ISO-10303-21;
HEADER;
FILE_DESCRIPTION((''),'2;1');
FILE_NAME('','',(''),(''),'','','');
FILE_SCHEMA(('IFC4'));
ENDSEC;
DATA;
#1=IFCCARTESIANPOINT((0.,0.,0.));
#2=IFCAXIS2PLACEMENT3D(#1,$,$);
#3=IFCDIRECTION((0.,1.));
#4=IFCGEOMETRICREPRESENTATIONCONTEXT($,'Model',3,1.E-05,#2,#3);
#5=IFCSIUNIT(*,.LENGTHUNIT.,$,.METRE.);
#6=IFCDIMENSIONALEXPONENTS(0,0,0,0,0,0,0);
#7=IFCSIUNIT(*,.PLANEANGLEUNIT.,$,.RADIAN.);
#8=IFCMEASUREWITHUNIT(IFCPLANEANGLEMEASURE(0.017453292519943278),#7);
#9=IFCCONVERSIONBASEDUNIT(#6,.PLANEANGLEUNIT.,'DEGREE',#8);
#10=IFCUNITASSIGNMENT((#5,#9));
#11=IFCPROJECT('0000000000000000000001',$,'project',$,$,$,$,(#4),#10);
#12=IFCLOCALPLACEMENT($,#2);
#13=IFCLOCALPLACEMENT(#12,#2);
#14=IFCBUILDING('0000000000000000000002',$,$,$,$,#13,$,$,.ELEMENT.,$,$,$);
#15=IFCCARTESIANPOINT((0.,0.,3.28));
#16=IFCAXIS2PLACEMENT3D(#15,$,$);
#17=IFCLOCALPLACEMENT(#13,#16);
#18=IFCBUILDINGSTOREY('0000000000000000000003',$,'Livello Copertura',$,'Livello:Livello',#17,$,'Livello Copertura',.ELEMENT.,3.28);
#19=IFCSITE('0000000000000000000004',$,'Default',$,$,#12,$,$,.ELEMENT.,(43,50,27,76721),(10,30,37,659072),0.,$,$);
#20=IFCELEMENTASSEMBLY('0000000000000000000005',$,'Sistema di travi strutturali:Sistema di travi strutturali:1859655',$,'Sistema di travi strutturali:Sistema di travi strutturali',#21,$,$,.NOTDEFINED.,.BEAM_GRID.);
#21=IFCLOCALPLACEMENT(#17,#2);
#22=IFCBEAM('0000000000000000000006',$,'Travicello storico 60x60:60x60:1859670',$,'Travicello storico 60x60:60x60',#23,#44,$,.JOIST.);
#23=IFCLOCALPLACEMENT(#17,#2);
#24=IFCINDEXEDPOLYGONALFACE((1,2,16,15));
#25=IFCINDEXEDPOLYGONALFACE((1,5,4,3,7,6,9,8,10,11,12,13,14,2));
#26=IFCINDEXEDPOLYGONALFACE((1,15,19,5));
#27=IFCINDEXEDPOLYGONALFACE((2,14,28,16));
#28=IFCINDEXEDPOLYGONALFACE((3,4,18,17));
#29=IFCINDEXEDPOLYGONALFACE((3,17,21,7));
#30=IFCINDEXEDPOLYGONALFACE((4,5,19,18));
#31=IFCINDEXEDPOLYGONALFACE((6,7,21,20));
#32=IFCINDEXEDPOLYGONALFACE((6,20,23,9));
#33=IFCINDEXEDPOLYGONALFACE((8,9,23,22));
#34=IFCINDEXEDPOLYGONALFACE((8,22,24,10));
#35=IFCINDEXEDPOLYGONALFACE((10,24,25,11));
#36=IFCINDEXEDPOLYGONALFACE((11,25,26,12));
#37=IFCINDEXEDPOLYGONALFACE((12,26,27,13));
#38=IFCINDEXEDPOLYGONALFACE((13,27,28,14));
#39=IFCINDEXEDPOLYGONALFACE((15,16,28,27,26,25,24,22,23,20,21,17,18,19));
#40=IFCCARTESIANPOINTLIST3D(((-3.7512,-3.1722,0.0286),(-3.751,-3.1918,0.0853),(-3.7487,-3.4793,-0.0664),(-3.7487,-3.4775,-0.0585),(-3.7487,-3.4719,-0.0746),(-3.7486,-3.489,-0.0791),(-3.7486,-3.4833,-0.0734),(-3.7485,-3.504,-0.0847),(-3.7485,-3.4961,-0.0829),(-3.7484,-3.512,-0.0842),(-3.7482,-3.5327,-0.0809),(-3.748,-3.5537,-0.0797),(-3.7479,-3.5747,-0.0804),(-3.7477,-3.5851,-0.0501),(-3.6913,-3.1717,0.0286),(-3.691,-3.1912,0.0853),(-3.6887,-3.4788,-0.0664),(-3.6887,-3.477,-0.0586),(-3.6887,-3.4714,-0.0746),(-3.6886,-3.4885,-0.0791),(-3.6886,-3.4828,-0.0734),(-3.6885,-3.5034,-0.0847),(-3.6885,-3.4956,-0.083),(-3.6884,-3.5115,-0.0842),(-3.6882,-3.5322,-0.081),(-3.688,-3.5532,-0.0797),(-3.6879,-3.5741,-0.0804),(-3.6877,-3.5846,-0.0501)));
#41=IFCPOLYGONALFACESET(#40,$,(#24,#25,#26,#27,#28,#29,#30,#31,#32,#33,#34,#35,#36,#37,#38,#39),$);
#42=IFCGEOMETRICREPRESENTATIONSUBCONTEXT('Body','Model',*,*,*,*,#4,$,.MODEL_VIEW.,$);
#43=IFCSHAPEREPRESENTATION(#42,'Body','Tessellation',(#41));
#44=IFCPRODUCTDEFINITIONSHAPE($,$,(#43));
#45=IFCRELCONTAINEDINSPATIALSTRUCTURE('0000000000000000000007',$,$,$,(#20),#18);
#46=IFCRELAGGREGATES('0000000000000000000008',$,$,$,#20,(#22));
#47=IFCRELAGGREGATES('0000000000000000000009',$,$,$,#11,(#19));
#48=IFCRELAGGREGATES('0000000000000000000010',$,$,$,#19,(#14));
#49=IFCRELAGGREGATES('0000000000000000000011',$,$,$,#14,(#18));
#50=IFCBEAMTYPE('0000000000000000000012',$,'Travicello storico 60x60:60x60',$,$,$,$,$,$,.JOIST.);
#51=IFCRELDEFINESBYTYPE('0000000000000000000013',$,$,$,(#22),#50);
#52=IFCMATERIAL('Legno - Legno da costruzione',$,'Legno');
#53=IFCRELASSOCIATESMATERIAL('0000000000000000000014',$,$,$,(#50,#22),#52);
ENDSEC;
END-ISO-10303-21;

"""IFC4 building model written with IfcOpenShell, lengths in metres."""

from ifc_helpers import new_model, entity, si_unit, converted_unit, direction, frame, origin, place, context, subcontext, project, spatial, line, arc, indexed_curve, outline, extrude, source, transform, mapped, material, type_object, type_shapes, element, aggregate, save


model = new_model("IFC4")

# Units and contexts
model_context = context("Model", 3, precision=1e-05, world=origin(), true_north=direction((0.0, 1.0)))
body_context = subcontext(model_context, "Body", "Model", "MODEL_VIEW")
ifc_project = project(units=[si_unit("LENGTHUNIT", "METRE"), converted_unit("PLANEANGLEUNIT", "DEGREE", entity("IfcPlaneAngleMeasure", 0.017453292519943278), si_unit("PLANEANGLEUNIT", "RADIAN"), dimensions=[0, 0, 0, 0, 0, 0, 0])], contexts=[model_context])

# Site, building, storey
site_placement = place(None, origin())
site = spatial("IfcSite", under=ifc_project, at=site_placement, Name="Default", CompositionType="ELEMENT", RefLatitude=(43, 50, 27, 76721), RefLongitude=(10, 30, 37, 659072), RefElevation=0.0)
building_placement = place(site_placement, origin())
building = spatial("IfcBuilding", under=site, at=building_placement, CompositionType="ELEMENT")
storey_placement = place(building_placement, frame((0.0, 0.0, 3.28)))
storey = spatial("IfcBuildingStorey", under=building, at=storey_placement, Name="Livello Copertura", ObjectType="Livello:Livello", LongName="Livello Copertura", CompositionType="ELEMENT", Elevation=3.28)

# Element assembly, beam
ifc_material = material(Name="Legno - Legno da costruzione", Category="Legno")
assembly_1_placement = place(storey_placement, origin())
assembly_1 = element("IfcElementAssembly", 1, at=assembly_1_placement, inside=storey, Name="Sistema di travi strutturali:Sistema di travi strutturali:1859655", ObjectType="Sistema di travi strutturali:Sistema di travi strutturali", AssemblyPlace="NOTDEFINED", PredefinedType="BEAM_GRID")
beam_type_1 = type_object("IfcBeamType", Name="Travicello storico 60x60:60x60", PredefinedType="JOIST", material=ifc_material)
shared_shape_1 = source(origin(), body_context, "Body", "SweptSolid", [
    extrude(outline(indexed_curve([(-0.0359, -0.2606), (0.0241, -0.2606), (0.0241, 0.0564), (0.0071, 0.0564), (0.0228, 0.074), (0.0201, 0.0974), (0.0061, 0.1256), (-0.0039, 0.1554), (-0.0359, 0.1554)], segments=[line(1, 2, 3, 4), arc(4, 5, 6), arc(6, 7, 8), line(8, 9, 1)], self_intersect=False)), frame((0.0874, -0.03, -0.0059), z_axis=(0.0, 1.0, 0.0), x_axis=(0.0, 0.0, -1.0)), (0.0, 0.0, 1.0), 0.06),
])
type_shapes(beam_type_1, [shared_shape_1])
beam_1_placement = place(assembly_1_placement, frame((-3.7184, -3.5108, -0.0564), z_axis=(0.003393, -0.32555, 0.945519), x_axis=(-0.007932, 0.945486, 0.325568)))
beam_1 = element("IfcBeam", 2, at=beam_1_placement, type_object=beam_type_1, material=ifc_material, Name="Travicello storico 60x60:60x60:1859670", ObjectType="Travicello storico 60x60:60x60", PredefinedType="JOIST", context=body_context, shape_type="MappedRepresentation", body=[
    mapped(shared_shape_1, transform((0.0, 0.0, 0.0), scale=1.0)),
])
aggregate(assembly_1, [beam_1])

save(model, "model.ifc")
